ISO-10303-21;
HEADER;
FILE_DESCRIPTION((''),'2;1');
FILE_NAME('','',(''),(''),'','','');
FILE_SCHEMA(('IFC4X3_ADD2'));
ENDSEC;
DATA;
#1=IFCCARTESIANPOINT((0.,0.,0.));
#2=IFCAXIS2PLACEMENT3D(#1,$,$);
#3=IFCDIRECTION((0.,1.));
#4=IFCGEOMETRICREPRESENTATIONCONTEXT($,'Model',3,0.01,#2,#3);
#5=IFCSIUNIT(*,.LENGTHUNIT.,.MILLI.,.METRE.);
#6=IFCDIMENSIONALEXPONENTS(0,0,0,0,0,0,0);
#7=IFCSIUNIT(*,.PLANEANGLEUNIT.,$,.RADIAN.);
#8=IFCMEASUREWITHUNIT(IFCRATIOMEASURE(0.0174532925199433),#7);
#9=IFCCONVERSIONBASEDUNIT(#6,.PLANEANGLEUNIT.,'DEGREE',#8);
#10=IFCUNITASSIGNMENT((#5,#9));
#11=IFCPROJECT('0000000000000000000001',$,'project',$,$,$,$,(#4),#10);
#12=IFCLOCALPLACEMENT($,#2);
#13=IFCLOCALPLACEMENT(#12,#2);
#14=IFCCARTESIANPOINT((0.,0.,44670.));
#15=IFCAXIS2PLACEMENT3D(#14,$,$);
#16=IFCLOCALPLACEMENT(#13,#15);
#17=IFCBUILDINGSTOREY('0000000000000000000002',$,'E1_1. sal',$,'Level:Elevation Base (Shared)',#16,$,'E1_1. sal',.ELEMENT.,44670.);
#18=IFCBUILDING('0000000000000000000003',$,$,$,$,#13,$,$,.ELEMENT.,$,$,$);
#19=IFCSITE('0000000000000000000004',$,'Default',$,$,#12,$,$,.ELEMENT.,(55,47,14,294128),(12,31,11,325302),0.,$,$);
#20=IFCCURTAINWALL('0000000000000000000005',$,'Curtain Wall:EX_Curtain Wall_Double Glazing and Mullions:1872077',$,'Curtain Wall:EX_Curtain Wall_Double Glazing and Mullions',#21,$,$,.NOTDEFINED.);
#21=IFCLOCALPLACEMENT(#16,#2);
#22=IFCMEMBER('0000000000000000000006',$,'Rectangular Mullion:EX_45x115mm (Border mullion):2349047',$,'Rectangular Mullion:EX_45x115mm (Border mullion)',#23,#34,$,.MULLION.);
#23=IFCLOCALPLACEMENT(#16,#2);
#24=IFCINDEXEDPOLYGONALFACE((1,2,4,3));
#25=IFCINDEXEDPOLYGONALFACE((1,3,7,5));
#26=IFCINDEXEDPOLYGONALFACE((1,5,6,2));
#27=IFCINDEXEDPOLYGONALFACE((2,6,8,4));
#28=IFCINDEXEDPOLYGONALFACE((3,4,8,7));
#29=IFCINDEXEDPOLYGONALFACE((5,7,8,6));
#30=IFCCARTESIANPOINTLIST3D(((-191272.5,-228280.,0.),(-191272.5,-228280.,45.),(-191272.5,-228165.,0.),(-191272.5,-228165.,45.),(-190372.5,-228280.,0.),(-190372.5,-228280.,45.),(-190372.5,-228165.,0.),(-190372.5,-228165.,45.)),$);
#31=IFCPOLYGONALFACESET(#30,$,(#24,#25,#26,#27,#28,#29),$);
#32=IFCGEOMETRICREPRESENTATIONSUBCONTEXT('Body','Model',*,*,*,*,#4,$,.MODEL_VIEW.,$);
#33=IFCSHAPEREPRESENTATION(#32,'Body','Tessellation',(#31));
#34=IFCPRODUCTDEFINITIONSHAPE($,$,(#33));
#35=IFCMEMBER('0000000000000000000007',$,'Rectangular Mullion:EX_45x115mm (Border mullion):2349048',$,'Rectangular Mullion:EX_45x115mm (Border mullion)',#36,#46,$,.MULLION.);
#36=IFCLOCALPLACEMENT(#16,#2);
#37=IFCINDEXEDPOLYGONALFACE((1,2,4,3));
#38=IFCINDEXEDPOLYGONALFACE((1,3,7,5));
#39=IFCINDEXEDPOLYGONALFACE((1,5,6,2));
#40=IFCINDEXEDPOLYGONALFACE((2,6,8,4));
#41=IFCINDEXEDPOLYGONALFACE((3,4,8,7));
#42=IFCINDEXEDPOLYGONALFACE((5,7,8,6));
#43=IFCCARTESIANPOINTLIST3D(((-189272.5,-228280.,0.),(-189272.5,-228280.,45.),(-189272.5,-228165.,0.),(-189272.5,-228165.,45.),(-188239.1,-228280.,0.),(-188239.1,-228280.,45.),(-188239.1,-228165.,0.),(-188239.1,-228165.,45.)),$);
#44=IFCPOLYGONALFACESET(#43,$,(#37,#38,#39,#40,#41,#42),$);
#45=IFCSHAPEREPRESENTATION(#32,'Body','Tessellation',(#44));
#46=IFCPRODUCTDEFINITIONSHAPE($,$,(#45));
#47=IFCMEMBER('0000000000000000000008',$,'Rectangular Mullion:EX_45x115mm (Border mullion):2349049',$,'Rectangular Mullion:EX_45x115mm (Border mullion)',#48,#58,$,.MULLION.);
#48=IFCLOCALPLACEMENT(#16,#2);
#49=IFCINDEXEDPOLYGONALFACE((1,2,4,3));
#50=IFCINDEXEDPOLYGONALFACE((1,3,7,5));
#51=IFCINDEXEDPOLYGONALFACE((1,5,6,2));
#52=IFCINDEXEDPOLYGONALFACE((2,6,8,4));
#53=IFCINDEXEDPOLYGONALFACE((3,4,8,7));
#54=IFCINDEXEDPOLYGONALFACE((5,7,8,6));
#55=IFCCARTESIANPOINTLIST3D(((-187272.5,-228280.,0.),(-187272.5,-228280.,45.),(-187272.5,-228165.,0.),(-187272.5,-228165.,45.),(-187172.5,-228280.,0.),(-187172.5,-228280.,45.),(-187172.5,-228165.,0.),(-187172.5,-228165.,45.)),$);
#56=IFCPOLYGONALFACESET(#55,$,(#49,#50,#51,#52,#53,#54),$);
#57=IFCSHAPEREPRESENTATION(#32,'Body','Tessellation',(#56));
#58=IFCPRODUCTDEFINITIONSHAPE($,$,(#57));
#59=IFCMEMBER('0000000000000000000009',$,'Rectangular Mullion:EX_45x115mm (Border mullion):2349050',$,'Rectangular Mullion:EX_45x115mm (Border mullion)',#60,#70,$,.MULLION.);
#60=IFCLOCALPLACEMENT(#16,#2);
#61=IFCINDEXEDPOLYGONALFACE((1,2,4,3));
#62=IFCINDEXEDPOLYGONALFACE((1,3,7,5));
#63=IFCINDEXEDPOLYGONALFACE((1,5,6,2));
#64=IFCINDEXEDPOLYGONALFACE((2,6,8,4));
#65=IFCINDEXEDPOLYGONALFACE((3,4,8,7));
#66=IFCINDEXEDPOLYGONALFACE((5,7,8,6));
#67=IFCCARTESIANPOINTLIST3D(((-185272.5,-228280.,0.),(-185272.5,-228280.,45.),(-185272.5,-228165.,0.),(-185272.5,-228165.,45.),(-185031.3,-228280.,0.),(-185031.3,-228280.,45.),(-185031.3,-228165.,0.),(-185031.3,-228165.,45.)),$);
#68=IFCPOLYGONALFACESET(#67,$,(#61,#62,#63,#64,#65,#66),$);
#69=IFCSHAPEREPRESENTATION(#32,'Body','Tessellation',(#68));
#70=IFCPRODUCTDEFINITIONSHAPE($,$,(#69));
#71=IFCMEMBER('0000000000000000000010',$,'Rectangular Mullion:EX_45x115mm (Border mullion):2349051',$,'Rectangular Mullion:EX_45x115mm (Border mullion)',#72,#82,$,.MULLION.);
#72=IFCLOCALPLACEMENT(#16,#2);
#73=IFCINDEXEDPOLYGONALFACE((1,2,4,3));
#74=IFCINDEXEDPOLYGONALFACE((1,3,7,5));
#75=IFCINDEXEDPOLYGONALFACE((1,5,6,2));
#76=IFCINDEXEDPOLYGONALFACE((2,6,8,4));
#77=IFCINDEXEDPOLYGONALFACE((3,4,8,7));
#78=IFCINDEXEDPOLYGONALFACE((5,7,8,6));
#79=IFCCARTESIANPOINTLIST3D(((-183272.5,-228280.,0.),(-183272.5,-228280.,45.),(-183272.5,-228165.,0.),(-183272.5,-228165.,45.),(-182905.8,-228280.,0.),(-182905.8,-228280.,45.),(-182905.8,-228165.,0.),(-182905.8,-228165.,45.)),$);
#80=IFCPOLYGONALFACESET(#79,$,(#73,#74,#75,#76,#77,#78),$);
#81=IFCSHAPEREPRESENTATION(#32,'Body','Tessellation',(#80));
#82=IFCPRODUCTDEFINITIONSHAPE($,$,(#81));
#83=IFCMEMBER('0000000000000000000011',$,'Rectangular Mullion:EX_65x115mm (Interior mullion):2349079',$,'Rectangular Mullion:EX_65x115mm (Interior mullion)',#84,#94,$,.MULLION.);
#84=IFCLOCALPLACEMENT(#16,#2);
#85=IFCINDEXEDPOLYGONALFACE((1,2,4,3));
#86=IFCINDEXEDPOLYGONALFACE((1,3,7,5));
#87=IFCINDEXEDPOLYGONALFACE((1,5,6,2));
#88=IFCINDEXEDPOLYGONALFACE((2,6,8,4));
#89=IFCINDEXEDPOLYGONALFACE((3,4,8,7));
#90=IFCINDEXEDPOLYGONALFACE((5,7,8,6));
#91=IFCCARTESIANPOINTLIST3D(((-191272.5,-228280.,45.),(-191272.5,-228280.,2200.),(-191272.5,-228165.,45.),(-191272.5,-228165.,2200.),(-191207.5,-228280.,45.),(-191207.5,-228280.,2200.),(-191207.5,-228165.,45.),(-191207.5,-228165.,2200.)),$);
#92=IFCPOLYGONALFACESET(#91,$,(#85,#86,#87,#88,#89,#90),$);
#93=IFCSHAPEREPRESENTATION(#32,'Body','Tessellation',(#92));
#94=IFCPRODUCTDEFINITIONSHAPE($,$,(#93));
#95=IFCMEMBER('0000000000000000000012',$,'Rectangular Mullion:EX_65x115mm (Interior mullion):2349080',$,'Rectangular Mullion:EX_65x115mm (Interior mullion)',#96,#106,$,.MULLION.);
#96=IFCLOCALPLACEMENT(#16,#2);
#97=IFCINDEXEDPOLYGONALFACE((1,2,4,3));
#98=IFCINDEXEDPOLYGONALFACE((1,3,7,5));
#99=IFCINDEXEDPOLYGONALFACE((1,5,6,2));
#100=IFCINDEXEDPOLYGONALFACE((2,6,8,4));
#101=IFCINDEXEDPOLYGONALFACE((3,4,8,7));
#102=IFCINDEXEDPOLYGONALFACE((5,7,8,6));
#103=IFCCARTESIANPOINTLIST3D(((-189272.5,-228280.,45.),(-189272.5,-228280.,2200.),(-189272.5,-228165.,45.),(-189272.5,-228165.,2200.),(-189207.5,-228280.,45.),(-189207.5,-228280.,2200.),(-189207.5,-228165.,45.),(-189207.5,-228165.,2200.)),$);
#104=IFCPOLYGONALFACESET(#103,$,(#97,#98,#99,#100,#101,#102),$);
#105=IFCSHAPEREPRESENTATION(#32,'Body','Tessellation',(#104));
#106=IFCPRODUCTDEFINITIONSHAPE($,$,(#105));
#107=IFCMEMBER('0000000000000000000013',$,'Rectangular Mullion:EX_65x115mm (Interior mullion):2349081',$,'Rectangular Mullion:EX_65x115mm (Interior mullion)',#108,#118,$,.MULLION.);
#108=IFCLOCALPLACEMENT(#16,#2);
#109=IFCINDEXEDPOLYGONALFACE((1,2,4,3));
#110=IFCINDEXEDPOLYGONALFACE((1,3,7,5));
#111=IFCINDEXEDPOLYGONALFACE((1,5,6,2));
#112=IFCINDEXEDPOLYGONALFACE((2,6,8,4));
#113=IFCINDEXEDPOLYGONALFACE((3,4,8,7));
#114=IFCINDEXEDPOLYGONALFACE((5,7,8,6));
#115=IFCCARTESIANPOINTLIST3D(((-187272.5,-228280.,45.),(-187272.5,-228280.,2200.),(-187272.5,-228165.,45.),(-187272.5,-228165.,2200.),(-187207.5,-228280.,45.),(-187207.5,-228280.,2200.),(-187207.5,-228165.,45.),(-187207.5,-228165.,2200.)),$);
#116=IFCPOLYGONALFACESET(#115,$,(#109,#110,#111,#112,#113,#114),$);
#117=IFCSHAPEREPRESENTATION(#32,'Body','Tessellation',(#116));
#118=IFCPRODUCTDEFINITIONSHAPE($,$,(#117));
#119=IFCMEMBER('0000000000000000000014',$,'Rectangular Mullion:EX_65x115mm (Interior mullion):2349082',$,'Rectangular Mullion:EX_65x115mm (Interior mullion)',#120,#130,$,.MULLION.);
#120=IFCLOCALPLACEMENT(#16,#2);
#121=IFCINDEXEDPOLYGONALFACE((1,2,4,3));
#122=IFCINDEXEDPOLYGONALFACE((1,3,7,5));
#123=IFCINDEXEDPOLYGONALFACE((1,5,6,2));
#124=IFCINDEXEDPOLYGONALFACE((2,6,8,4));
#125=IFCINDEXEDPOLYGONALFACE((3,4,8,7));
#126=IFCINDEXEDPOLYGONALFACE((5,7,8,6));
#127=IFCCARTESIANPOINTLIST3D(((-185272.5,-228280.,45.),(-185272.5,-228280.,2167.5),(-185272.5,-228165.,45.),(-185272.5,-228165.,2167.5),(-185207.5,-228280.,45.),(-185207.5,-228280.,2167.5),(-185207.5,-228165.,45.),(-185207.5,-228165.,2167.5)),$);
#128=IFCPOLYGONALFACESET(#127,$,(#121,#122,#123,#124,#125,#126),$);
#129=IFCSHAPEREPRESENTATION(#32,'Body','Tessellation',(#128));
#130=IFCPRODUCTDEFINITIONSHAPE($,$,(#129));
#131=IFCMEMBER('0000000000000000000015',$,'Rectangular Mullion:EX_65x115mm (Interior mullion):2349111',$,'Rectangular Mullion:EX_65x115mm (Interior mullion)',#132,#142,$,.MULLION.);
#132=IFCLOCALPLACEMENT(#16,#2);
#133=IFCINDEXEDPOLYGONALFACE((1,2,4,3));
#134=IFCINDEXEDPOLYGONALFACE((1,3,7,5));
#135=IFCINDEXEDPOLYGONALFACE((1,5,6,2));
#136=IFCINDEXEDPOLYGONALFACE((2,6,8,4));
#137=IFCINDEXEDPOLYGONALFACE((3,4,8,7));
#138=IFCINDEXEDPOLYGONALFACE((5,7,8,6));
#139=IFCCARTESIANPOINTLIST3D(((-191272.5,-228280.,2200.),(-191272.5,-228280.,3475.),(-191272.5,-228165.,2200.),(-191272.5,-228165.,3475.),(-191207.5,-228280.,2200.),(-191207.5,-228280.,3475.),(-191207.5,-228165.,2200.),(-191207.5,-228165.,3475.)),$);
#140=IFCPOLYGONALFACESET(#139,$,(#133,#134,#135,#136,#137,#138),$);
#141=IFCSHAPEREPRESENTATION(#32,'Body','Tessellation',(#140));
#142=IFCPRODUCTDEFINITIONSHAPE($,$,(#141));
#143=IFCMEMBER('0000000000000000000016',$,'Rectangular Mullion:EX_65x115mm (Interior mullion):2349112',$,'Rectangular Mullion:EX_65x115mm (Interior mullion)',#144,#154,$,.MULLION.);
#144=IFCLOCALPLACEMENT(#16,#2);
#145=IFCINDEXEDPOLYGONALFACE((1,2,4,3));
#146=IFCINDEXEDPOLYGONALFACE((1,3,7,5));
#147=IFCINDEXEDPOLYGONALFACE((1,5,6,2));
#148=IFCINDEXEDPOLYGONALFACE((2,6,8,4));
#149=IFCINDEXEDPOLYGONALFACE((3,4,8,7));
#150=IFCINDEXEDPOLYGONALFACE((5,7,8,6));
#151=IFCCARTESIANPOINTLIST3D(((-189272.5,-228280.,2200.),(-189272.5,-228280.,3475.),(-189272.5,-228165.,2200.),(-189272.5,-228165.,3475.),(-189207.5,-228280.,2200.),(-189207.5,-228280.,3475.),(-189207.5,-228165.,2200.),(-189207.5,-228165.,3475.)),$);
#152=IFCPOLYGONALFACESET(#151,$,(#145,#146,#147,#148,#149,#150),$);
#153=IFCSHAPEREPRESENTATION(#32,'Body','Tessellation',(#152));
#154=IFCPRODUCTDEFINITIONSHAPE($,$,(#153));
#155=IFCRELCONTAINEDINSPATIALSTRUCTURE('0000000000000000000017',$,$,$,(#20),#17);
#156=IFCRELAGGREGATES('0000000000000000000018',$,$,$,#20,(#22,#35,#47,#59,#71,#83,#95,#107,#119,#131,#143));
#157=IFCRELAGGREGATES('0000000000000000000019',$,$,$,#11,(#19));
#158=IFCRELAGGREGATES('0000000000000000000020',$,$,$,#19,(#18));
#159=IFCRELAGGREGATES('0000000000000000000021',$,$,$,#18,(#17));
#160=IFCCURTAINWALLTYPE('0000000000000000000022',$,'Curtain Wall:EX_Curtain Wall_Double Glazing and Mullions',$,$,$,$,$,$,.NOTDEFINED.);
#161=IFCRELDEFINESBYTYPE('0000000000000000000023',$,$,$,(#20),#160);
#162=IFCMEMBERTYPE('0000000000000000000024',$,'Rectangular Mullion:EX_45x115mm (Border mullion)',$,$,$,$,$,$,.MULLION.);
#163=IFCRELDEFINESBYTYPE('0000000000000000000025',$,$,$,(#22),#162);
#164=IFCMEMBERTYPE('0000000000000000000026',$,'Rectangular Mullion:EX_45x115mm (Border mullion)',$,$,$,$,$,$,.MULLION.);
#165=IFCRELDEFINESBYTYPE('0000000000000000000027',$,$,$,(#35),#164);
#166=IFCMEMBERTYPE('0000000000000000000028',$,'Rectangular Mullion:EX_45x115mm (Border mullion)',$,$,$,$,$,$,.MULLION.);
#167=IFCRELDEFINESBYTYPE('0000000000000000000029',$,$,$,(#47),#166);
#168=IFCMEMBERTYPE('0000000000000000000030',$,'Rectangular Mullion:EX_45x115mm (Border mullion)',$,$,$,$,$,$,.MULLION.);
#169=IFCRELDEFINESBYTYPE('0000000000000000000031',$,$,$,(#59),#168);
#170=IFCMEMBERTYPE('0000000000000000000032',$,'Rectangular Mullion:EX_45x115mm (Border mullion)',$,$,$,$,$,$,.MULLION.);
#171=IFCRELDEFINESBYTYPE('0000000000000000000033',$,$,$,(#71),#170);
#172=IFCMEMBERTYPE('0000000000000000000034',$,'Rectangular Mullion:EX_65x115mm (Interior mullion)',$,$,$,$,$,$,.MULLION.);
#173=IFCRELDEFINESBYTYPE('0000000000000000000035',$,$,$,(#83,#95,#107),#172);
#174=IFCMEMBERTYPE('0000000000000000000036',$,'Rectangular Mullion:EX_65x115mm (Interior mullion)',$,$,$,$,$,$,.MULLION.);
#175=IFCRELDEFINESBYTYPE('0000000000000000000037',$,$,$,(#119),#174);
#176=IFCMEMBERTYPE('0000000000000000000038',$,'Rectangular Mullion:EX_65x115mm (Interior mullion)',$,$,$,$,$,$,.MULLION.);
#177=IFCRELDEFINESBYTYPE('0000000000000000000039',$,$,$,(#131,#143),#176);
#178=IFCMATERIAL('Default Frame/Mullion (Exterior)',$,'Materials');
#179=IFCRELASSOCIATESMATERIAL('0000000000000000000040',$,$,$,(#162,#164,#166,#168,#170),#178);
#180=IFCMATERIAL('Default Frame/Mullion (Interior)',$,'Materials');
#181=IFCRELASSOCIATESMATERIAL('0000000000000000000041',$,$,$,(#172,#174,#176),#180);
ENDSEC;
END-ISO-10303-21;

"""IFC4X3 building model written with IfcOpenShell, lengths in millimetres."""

from ifc_helpers import new_model, entity, si_unit, converted_unit, direction, frame, origin, origin_2d_with_axis, place, context, subcontext, project, spatial, rectangle, extrude, source, transform, mapped, material, material_profile, profile_set, type_object, type_shapes, element, aggregate, save


model = new_model("IFC4X3")

# Units and contexts
model_context = context("Model", 3, precision=0.01, world=origin(), true_north=direction((0.0, 1.0)))
body_context = subcontext(model_context, "Body", "Model", "MODEL_VIEW")
ifc_project = project(units=[si_unit("LENGTHUNIT", "METRE", prefix="MILLI"), converted_unit("PLANEANGLEUNIT", "DEGREE", entity("IfcRatioMeasure", 0.0174532925199433), si_unit("PLANEANGLEUNIT", "RADIAN"), dimensions=[0, 0, 0, 0, 0, 0, 0])], contexts=[model_context])

# Site, building, storey
site_placement = place(None, origin())
site = spatial("IfcSite", under=ifc_project, at=site_placement, Name="Default", CompositionType="ELEMENT", RefLatitude=(55, 47, 14, 294128), RefLongitude=(12, 31, 11, 325302), RefElevation=0.0)
building_placement = place(site_placement, origin())
building = spatial("IfcBuilding", under=site, at=building_placement, CompositionType="ELEMENT")
storey_placement = place(building_placement, frame((0.0, 0.0, 44670.0)))
storey = spatial("IfcBuildingStorey", under=building, at=storey_placement, Name="E1_1. sal", ObjectType="Level:Elevation Base (Shared)", LongName="E1_1. sal", CompositionType="ELEMENT", Elevation=44670.0)

# Curtain wall, members
curtain_wall_type = type_object("IfcCurtainWallType", Name="Curtain Wall:EX_Curtain Wall_Double Glazing and Mullions", PredefinedType="NOTDEFINED")
curtain_wall_placement = place(storey_placement, frame((0.0, 0.0, -44670.0)))
curtain_wall = element("IfcCurtainWall", 1, at=curtain_wall_placement, inside=storey, type_object=curtain_wall_type, Name="Curtain Wall:EX_Curtain Wall_Double Glazing and Mullions:1872077", ObjectType="Curtain Wall:EX_Curtain Wall_Double Glazing and Mullions", PredefinedType="NOTDEFINED")
ifc_material_1 = material(Name="Default Frame/Mullion (Interior)", Category="Materials")
ifc_material_profile_1 = material_profile(ifc_material_1, rectangle(XDim=115.0, YDim=65.0, at=origin_2d_with_axis()), Name="EX_65x115mm (Interior mullion)")
ifc_profile_set_1 = profile_set([ifc_material_profile_1], Name="EX_65x115mm (Interior mullion)")
ifc_material_2 = material(Name="Default Frame/Mullion (Exterior)", Category="Materials")
ifc_material_profile_2 = material_profile(ifc_material_2, rectangle(XDim=115.0, YDim=45.0, at=origin_2d_with_axis()), Name="EX_45x115mm (Border mullion)")
ifc_profile_set_2 = profile_set([ifc_material_profile_2], Name="EX_45x115mm (Border mullion)")
member_type_1 = type_object("IfcMemberType", Name="Rectangular Mullion:EX_45x115mm (Border mullion)", PredefinedType="MULLION", material=ifc_profile_set_2)
shared_shape_1 = source(origin(), body_context, "Body", "SweptSolid", [
    extrude(rectangle(XDim=115.0, YDim=45.0, at=origin_2d_with_axis()), frame((-22.5, -57.5, -900.0), z_axis=(0.0, 0.0, 1.0), x_axis=(0.0, -1.0, 0.0)), (0.0, 0.0, 1.0), 900.0),
])
type_shapes(member_type_1, [shared_shape_1])
member_1_placement = place(curtain_wall_placement, frame((-191272.5, -228280.0, 44670.0), z_axis=(-1.0, 0.0, 0.0), x_axis=(0.0, 0.0, -1.0)))
member_1 = element("IfcMember", 2, at=member_1_placement, type_object=member_type_1, Name="Rectangular Mullion:EX_45x115mm (Border mullion):2349047", ObjectType="Rectangular Mullion:EX_45x115mm (Border mullion)", PredefinedType="MULLION", context=body_context, shape_type="MappedRepresentation", body=[
    mapped(shared_shape_1, transform((0.0, 0.0, 0.0), scale=1.0)),
])
member_type_2 = type_object("IfcMemberType", Name="Rectangular Mullion:EX_45x115mm (Border mullion)", PredefinedType="MULLION", material=ifc_profile_set_2)
shared_shape_2 = source(origin(), body_context, "Body", "SweptSolid", [
    extrude(rectangle(XDim=115.0, YDim=45.0, at=origin_2d_with_axis()), frame((-22.5, -57.5, -1033.4), z_axis=(0.0, 0.0, 1.0), x_axis=(0.0, -1.0, 0.0)), (0.0, 0.0, 1.0), 1033.4),
])
type_shapes(member_type_2, [shared_shape_2])
member_2_placement = place(curtain_wall_placement, frame((-189272.5, -228280.0, 44670.0), z_axis=(-1.0, 0.0, 0.0), x_axis=(0.0, 0.0, -1.0)))
member_2 = element("IfcMember", 3, at=member_2_placement, type_object=member_type_2, Name="Rectangular Mullion:EX_45x115mm (Border mullion):2349048", ObjectType="Rectangular Mullion:EX_45x115mm (Border mullion)", PredefinedType="MULLION", context=body_context, shape_type="MappedRepresentation", body=[
    mapped(shared_shape_2, transform((0.0, 0.0, 0.0), scale=1.0)),
])
member_type_3 = type_object("IfcMemberType", Name="Rectangular Mullion:EX_45x115mm (Border mullion)", PredefinedType="MULLION", material=ifc_profile_set_2)
shared_shape_3 = source(origin(), body_context, "Body", "SweptSolid", [
    extrude(rectangle(XDim=115.0, YDim=45.0, at=origin_2d_with_axis()), frame((-22.5, -57.5, -100.0), z_axis=(0.0, 0.0, 1.0), x_axis=(0.0, -1.0, 0.0)), (0.0, 0.0, 1.0), 100.0),
])
type_shapes(member_type_3, [shared_shape_3])
member_3_placement = place(curtain_wall_placement, frame((-187272.5, -228280.0, 44670.0), z_axis=(-1.0, 0.0, 0.0), x_axis=(0.0, 0.0, -1.0)))
member_3 = element("IfcMember", 4, at=member_3_placement, type_object=member_type_3, Name="Rectangular Mullion:EX_45x115mm (Border mullion):2349049", ObjectType="Rectangular Mullion:EX_45x115mm (Border mullion)", PredefinedType="MULLION", context=body_context, shape_type="MappedRepresentation", body=[
    mapped(shared_shape_3, transform((0.0, 0.0, 0.0), scale=1.0)),
])
member_type_4 = type_object("IfcMemberType", Name="Rectangular Mullion:EX_45x115mm (Border mullion)", PredefinedType="MULLION", material=ifc_profile_set_2)
shared_shape_4 = source(origin(), body_context, "Body", "SweptSolid", [
    extrude(rectangle(XDim=115.0, YDim=45.0, at=origin_2d_with_axis()), frame((-22.5, -57.5, -241.2), z_axis=(0.0, 0.0, 1.0), x_axis=(0.0, -1.0, 0.0)), (0.0, 0.0, 1.0), 241.2),
])
type_shapes(member_type_4, [shared_shape_4])
member_4_placement = place(curtain_wall_placement, frame((-185272.5, -228280.0, 44670.0), z_axis=(-1.0, 0.0, 0.0), x_axis=(0.0, 0.0, -1.0)))
member_4 = element("IfcMember", 5, at=member_4_placement, type_object=member_type_4, Name="Rectangular Mullion:EX_45x115mm (Border mullion):2349050", ObjectType="Rectangular Mullion:EX_45x115mm (Border mullion)", PredefinedType="MULLION", context=body_context, shape_type="MappedRepresentation", body=[
    mapped(shared_shape_4, transform((0.0, 0.0, 0.0), scale=1.0)),
])
member_type_5 = type_object("IfcMemberType", Name="Rectangular Mullion:EX_45x115mm (Border mullion)", PredefinedType="MULLION", material=ifc_profile_set_2)
shared_shape_5 = source(origin(), body_context, "Body", "SweptSolid", [
    extrude(rectangle(XDim=115.0, YDim=45.0, at=origin_2d_with_axis()), frame((-22.5, -57.5, -366.7), z_axis=(0.0, 0.0, 1.0), x_axis=(0.0, -1.0, 0.0)), (0.0, 0.0, 1.0), 366.7),
])
type_shapes(member_type_5, [shared_shape_5])
member_5_placement = place(curtain_wall_placement, frame((-183272.5, -228280.0, 44670.0), z_axis=(-1.0, 0.0, 0.0), x_axis=(0.0, 0.0, -1.0)))
member_5 = element("IfcMember", 6, at=member_5_placement, type_object=member_type_5, Name="Rectangular Mullion:EX_45x115mm (Border mullion):2349051", ObjectType="Rectangular Mullion:EX_45x115mm (Border mullion)", PredefinedType="MULLION", context=body_context, shape_type="MappedRepresentation", body=[
    mapped(shared_shape_5, transform((0.0, 0.0, 0.0), scale=1.0)),
])
member_type_6 = type_object("IfcMemberType", Name="Rectangular Mullion:EX_65x115mm (Interior mullion)", PredefinedType="MULLION", material=ifc_profile_set_1)
shared_shape_6 = source(origin(), body_context, "Body", "SweptSolid", [
    extrude(rectangle(XDim=115.0, YDim=65.0, at=origin_2d_with_axis()), frame((0.0, -57.5, -2155.0), z_axis=(0.0, 0.0, 1.0), x_axis=(0.0, -1.0, 0.0)), (0.0, 0.0, 1.0), 2155.0),
])
type_shapes(member_type_6, [shared_shape_6])
member_6_placement = place(curtain_wall_placement, frame((-191240.0, -228280.0, 44715.0), z_axis=(0.0, 0.0, -1.0), x_axis=(1.0, 0.0, 0.0)))
member_6 = element("IfcMember", 7, at=member_6_placement, type_object=member_type_6, Name="Rectangular Mullion:EX_65x115mm (Interior mullion):2349079", ObjectType="Rectangular Mullion:EX_65x115mm (Interior mullion)", PredefinedType="MULLION", context=body_context, shape_type="MappedRepresentation", body=[
    mapped(shared_shape_6, transform((0.0, 0.0, 0.0), scale=1.0)),
])
member_7_placement = place(curtain_wall_placement, frame((-189240.0, -228280.0, 44715.0), z_axis=(0.0, 0.0, -1.0), x_axis=(1.0, 0.0, 0.0)))
member_7 = element("IfcMember", 8, at=member_7_placement, type_object=member_type_6, Name="Rectangular Mullion:EX_65x115mm (Interior mullion):2349080", ObjectType="Rectangular Mullion:EX_65x115mm (Interior mullion)", PredefinedType="MULLION", context=body_context, shape_type="MappedRepresentation", body=[
    mapped(shared_shape_6, transform((0.0, 0.0, 0.0), scale=1.0)),
])
member_8_placement = place(curtain_wall_placement, frame((-187240.0, -228280.0, 44715.0), z_axis=(0.0, 0.0, -1.0), x_axis=(1.0, 0.0, 0.0)))
member_8 = element("IfcMember", 9, at=member_8_placement, type_object=member_type_6, Name="Rectangular Mullion:EX_65x115mm (Interior mullion):2349081", ObjectType="Rectangular Mullion:EX_65x115mm (Interior mullion)", PredefinedType="MULLION", context=body_context, shape_type="MappedRepresentation", body=[
    mapped(shared_shape_6, transform((0.0, 0.0, 0.0), scale=1.0)),
])
member_type_7 = type_object("IfcMemberType", Name="Rectangular Mullion:EX_65x115mm (Interior mullion)", PredefinedType="MULLION", material=ifc_profile_set_1)
shared_shape_7 = source(origin(), body_context, "Body", "SweptSolid", [
    extrude(rectangle(XDim=115.0, YDim=65.0, at=origin_2d_with_axis()), frame((0.0, -57.5, -2122.5), z_axis=(0.0, 0.0, 1.0), x_axis=(0.0, -1.0, 0.0)), (0.0, 0.0, 1.0), 2122.5),
])
type_shapes(member_type_7, [shared_shape_7])
member_9_placement = place(curtain_wall_placement, frame((-185240.0, -228280.0, 44715.0), z_axis=(0.0, 0.0, -1.0), x_axis=(1.0, 0.0, 0.0)))
member_9 = element("IfcMember", 10, at=member_9_placement, type_object=member_type_7, Name="Rectangular Mullion:EX_65x115mm (Interior mullion):2349082", ObjectType="Rectangular Mullion:EX_65x115mm (Interior mullion)", PredefinedType="MULLION", context=body_context, shape_type="MappedRepresentation", body=[
    mapped(shared_shape_7, transform((0.0, 0.0, 0.0), scale=1.0)),
])
member_type_8 = type_object("IfcMemberType", Name="Rectangular Mullion:EX_65x115mm (Interior mullion)", PredefinedType="MULLION", material=ifc_profile_set_1)
shared_shape_8 = source(origin(), body_context, "Body", "SweptSolid", [
    extrude(rectangle(XDim=115.0, YDim=65.0, at=origin_2d_with_axis()), frame((0.0, -57.5, -1275.0), z_axis=(0.0, 0.0, 1.0), x_axis=(0.0, -1.0, 0.0)), (0.0, 0.0, 1.0), 1275.0),
])
type_shapes(member_type_8, [shared_shape_8])
member_10_placement = place(curtain_wall_placement, frame((-191240.0, -228280.0, 46870.0), z_axis=(0.0, 0.0, -1.0), x_axis=(1.0, 0.0, 0.0)))
member_10 = element("IfcMember", 11, at=member_10_placement, type_object=member_type_8, Name="Rectangular Mullion:EX_65x115mm (Interior mullion):2349111", ObjectType="Rectangular Mullion:EX_65x115mm (Interior mullion)", PredefinedType="MULLION", context=body_context, shape_type="MappedRepresentation", body=[
    mapped(shared_shape_8, transform((0.0, 0.0, 0.0), scale=1.0)),
])
member_11_placement = place(curtain_wall_placement, frame((-189240.0, -228280.0, 46870.0), z_axis=(0.0, 0.0, -1.0), x_axis=(1.0, 0.0, 0.0)))
member_11 = element("IfcMember", 12, at=member_11_placement, type_object=member_type_8, Name="Rectangular Mullion:EX_65x115mm (Interior mullion):2349112", ObjectType="Rectangular Mullion:EX_65x115mm (Interior mullion)", PredefinedType="MULLION", context=body_context, shape_type="MappedRepresentation", body=[
    mapped(shared_shape_8, transform((0.0, 0.0, 0.0), scale=1.0)),
])
aggregate(curtain_wall, [member_1, member_2, member_3, member_4, member_5, member_6, member_7, member_8, member_9, member_10, member_11])

save(model, "model.ifc")
